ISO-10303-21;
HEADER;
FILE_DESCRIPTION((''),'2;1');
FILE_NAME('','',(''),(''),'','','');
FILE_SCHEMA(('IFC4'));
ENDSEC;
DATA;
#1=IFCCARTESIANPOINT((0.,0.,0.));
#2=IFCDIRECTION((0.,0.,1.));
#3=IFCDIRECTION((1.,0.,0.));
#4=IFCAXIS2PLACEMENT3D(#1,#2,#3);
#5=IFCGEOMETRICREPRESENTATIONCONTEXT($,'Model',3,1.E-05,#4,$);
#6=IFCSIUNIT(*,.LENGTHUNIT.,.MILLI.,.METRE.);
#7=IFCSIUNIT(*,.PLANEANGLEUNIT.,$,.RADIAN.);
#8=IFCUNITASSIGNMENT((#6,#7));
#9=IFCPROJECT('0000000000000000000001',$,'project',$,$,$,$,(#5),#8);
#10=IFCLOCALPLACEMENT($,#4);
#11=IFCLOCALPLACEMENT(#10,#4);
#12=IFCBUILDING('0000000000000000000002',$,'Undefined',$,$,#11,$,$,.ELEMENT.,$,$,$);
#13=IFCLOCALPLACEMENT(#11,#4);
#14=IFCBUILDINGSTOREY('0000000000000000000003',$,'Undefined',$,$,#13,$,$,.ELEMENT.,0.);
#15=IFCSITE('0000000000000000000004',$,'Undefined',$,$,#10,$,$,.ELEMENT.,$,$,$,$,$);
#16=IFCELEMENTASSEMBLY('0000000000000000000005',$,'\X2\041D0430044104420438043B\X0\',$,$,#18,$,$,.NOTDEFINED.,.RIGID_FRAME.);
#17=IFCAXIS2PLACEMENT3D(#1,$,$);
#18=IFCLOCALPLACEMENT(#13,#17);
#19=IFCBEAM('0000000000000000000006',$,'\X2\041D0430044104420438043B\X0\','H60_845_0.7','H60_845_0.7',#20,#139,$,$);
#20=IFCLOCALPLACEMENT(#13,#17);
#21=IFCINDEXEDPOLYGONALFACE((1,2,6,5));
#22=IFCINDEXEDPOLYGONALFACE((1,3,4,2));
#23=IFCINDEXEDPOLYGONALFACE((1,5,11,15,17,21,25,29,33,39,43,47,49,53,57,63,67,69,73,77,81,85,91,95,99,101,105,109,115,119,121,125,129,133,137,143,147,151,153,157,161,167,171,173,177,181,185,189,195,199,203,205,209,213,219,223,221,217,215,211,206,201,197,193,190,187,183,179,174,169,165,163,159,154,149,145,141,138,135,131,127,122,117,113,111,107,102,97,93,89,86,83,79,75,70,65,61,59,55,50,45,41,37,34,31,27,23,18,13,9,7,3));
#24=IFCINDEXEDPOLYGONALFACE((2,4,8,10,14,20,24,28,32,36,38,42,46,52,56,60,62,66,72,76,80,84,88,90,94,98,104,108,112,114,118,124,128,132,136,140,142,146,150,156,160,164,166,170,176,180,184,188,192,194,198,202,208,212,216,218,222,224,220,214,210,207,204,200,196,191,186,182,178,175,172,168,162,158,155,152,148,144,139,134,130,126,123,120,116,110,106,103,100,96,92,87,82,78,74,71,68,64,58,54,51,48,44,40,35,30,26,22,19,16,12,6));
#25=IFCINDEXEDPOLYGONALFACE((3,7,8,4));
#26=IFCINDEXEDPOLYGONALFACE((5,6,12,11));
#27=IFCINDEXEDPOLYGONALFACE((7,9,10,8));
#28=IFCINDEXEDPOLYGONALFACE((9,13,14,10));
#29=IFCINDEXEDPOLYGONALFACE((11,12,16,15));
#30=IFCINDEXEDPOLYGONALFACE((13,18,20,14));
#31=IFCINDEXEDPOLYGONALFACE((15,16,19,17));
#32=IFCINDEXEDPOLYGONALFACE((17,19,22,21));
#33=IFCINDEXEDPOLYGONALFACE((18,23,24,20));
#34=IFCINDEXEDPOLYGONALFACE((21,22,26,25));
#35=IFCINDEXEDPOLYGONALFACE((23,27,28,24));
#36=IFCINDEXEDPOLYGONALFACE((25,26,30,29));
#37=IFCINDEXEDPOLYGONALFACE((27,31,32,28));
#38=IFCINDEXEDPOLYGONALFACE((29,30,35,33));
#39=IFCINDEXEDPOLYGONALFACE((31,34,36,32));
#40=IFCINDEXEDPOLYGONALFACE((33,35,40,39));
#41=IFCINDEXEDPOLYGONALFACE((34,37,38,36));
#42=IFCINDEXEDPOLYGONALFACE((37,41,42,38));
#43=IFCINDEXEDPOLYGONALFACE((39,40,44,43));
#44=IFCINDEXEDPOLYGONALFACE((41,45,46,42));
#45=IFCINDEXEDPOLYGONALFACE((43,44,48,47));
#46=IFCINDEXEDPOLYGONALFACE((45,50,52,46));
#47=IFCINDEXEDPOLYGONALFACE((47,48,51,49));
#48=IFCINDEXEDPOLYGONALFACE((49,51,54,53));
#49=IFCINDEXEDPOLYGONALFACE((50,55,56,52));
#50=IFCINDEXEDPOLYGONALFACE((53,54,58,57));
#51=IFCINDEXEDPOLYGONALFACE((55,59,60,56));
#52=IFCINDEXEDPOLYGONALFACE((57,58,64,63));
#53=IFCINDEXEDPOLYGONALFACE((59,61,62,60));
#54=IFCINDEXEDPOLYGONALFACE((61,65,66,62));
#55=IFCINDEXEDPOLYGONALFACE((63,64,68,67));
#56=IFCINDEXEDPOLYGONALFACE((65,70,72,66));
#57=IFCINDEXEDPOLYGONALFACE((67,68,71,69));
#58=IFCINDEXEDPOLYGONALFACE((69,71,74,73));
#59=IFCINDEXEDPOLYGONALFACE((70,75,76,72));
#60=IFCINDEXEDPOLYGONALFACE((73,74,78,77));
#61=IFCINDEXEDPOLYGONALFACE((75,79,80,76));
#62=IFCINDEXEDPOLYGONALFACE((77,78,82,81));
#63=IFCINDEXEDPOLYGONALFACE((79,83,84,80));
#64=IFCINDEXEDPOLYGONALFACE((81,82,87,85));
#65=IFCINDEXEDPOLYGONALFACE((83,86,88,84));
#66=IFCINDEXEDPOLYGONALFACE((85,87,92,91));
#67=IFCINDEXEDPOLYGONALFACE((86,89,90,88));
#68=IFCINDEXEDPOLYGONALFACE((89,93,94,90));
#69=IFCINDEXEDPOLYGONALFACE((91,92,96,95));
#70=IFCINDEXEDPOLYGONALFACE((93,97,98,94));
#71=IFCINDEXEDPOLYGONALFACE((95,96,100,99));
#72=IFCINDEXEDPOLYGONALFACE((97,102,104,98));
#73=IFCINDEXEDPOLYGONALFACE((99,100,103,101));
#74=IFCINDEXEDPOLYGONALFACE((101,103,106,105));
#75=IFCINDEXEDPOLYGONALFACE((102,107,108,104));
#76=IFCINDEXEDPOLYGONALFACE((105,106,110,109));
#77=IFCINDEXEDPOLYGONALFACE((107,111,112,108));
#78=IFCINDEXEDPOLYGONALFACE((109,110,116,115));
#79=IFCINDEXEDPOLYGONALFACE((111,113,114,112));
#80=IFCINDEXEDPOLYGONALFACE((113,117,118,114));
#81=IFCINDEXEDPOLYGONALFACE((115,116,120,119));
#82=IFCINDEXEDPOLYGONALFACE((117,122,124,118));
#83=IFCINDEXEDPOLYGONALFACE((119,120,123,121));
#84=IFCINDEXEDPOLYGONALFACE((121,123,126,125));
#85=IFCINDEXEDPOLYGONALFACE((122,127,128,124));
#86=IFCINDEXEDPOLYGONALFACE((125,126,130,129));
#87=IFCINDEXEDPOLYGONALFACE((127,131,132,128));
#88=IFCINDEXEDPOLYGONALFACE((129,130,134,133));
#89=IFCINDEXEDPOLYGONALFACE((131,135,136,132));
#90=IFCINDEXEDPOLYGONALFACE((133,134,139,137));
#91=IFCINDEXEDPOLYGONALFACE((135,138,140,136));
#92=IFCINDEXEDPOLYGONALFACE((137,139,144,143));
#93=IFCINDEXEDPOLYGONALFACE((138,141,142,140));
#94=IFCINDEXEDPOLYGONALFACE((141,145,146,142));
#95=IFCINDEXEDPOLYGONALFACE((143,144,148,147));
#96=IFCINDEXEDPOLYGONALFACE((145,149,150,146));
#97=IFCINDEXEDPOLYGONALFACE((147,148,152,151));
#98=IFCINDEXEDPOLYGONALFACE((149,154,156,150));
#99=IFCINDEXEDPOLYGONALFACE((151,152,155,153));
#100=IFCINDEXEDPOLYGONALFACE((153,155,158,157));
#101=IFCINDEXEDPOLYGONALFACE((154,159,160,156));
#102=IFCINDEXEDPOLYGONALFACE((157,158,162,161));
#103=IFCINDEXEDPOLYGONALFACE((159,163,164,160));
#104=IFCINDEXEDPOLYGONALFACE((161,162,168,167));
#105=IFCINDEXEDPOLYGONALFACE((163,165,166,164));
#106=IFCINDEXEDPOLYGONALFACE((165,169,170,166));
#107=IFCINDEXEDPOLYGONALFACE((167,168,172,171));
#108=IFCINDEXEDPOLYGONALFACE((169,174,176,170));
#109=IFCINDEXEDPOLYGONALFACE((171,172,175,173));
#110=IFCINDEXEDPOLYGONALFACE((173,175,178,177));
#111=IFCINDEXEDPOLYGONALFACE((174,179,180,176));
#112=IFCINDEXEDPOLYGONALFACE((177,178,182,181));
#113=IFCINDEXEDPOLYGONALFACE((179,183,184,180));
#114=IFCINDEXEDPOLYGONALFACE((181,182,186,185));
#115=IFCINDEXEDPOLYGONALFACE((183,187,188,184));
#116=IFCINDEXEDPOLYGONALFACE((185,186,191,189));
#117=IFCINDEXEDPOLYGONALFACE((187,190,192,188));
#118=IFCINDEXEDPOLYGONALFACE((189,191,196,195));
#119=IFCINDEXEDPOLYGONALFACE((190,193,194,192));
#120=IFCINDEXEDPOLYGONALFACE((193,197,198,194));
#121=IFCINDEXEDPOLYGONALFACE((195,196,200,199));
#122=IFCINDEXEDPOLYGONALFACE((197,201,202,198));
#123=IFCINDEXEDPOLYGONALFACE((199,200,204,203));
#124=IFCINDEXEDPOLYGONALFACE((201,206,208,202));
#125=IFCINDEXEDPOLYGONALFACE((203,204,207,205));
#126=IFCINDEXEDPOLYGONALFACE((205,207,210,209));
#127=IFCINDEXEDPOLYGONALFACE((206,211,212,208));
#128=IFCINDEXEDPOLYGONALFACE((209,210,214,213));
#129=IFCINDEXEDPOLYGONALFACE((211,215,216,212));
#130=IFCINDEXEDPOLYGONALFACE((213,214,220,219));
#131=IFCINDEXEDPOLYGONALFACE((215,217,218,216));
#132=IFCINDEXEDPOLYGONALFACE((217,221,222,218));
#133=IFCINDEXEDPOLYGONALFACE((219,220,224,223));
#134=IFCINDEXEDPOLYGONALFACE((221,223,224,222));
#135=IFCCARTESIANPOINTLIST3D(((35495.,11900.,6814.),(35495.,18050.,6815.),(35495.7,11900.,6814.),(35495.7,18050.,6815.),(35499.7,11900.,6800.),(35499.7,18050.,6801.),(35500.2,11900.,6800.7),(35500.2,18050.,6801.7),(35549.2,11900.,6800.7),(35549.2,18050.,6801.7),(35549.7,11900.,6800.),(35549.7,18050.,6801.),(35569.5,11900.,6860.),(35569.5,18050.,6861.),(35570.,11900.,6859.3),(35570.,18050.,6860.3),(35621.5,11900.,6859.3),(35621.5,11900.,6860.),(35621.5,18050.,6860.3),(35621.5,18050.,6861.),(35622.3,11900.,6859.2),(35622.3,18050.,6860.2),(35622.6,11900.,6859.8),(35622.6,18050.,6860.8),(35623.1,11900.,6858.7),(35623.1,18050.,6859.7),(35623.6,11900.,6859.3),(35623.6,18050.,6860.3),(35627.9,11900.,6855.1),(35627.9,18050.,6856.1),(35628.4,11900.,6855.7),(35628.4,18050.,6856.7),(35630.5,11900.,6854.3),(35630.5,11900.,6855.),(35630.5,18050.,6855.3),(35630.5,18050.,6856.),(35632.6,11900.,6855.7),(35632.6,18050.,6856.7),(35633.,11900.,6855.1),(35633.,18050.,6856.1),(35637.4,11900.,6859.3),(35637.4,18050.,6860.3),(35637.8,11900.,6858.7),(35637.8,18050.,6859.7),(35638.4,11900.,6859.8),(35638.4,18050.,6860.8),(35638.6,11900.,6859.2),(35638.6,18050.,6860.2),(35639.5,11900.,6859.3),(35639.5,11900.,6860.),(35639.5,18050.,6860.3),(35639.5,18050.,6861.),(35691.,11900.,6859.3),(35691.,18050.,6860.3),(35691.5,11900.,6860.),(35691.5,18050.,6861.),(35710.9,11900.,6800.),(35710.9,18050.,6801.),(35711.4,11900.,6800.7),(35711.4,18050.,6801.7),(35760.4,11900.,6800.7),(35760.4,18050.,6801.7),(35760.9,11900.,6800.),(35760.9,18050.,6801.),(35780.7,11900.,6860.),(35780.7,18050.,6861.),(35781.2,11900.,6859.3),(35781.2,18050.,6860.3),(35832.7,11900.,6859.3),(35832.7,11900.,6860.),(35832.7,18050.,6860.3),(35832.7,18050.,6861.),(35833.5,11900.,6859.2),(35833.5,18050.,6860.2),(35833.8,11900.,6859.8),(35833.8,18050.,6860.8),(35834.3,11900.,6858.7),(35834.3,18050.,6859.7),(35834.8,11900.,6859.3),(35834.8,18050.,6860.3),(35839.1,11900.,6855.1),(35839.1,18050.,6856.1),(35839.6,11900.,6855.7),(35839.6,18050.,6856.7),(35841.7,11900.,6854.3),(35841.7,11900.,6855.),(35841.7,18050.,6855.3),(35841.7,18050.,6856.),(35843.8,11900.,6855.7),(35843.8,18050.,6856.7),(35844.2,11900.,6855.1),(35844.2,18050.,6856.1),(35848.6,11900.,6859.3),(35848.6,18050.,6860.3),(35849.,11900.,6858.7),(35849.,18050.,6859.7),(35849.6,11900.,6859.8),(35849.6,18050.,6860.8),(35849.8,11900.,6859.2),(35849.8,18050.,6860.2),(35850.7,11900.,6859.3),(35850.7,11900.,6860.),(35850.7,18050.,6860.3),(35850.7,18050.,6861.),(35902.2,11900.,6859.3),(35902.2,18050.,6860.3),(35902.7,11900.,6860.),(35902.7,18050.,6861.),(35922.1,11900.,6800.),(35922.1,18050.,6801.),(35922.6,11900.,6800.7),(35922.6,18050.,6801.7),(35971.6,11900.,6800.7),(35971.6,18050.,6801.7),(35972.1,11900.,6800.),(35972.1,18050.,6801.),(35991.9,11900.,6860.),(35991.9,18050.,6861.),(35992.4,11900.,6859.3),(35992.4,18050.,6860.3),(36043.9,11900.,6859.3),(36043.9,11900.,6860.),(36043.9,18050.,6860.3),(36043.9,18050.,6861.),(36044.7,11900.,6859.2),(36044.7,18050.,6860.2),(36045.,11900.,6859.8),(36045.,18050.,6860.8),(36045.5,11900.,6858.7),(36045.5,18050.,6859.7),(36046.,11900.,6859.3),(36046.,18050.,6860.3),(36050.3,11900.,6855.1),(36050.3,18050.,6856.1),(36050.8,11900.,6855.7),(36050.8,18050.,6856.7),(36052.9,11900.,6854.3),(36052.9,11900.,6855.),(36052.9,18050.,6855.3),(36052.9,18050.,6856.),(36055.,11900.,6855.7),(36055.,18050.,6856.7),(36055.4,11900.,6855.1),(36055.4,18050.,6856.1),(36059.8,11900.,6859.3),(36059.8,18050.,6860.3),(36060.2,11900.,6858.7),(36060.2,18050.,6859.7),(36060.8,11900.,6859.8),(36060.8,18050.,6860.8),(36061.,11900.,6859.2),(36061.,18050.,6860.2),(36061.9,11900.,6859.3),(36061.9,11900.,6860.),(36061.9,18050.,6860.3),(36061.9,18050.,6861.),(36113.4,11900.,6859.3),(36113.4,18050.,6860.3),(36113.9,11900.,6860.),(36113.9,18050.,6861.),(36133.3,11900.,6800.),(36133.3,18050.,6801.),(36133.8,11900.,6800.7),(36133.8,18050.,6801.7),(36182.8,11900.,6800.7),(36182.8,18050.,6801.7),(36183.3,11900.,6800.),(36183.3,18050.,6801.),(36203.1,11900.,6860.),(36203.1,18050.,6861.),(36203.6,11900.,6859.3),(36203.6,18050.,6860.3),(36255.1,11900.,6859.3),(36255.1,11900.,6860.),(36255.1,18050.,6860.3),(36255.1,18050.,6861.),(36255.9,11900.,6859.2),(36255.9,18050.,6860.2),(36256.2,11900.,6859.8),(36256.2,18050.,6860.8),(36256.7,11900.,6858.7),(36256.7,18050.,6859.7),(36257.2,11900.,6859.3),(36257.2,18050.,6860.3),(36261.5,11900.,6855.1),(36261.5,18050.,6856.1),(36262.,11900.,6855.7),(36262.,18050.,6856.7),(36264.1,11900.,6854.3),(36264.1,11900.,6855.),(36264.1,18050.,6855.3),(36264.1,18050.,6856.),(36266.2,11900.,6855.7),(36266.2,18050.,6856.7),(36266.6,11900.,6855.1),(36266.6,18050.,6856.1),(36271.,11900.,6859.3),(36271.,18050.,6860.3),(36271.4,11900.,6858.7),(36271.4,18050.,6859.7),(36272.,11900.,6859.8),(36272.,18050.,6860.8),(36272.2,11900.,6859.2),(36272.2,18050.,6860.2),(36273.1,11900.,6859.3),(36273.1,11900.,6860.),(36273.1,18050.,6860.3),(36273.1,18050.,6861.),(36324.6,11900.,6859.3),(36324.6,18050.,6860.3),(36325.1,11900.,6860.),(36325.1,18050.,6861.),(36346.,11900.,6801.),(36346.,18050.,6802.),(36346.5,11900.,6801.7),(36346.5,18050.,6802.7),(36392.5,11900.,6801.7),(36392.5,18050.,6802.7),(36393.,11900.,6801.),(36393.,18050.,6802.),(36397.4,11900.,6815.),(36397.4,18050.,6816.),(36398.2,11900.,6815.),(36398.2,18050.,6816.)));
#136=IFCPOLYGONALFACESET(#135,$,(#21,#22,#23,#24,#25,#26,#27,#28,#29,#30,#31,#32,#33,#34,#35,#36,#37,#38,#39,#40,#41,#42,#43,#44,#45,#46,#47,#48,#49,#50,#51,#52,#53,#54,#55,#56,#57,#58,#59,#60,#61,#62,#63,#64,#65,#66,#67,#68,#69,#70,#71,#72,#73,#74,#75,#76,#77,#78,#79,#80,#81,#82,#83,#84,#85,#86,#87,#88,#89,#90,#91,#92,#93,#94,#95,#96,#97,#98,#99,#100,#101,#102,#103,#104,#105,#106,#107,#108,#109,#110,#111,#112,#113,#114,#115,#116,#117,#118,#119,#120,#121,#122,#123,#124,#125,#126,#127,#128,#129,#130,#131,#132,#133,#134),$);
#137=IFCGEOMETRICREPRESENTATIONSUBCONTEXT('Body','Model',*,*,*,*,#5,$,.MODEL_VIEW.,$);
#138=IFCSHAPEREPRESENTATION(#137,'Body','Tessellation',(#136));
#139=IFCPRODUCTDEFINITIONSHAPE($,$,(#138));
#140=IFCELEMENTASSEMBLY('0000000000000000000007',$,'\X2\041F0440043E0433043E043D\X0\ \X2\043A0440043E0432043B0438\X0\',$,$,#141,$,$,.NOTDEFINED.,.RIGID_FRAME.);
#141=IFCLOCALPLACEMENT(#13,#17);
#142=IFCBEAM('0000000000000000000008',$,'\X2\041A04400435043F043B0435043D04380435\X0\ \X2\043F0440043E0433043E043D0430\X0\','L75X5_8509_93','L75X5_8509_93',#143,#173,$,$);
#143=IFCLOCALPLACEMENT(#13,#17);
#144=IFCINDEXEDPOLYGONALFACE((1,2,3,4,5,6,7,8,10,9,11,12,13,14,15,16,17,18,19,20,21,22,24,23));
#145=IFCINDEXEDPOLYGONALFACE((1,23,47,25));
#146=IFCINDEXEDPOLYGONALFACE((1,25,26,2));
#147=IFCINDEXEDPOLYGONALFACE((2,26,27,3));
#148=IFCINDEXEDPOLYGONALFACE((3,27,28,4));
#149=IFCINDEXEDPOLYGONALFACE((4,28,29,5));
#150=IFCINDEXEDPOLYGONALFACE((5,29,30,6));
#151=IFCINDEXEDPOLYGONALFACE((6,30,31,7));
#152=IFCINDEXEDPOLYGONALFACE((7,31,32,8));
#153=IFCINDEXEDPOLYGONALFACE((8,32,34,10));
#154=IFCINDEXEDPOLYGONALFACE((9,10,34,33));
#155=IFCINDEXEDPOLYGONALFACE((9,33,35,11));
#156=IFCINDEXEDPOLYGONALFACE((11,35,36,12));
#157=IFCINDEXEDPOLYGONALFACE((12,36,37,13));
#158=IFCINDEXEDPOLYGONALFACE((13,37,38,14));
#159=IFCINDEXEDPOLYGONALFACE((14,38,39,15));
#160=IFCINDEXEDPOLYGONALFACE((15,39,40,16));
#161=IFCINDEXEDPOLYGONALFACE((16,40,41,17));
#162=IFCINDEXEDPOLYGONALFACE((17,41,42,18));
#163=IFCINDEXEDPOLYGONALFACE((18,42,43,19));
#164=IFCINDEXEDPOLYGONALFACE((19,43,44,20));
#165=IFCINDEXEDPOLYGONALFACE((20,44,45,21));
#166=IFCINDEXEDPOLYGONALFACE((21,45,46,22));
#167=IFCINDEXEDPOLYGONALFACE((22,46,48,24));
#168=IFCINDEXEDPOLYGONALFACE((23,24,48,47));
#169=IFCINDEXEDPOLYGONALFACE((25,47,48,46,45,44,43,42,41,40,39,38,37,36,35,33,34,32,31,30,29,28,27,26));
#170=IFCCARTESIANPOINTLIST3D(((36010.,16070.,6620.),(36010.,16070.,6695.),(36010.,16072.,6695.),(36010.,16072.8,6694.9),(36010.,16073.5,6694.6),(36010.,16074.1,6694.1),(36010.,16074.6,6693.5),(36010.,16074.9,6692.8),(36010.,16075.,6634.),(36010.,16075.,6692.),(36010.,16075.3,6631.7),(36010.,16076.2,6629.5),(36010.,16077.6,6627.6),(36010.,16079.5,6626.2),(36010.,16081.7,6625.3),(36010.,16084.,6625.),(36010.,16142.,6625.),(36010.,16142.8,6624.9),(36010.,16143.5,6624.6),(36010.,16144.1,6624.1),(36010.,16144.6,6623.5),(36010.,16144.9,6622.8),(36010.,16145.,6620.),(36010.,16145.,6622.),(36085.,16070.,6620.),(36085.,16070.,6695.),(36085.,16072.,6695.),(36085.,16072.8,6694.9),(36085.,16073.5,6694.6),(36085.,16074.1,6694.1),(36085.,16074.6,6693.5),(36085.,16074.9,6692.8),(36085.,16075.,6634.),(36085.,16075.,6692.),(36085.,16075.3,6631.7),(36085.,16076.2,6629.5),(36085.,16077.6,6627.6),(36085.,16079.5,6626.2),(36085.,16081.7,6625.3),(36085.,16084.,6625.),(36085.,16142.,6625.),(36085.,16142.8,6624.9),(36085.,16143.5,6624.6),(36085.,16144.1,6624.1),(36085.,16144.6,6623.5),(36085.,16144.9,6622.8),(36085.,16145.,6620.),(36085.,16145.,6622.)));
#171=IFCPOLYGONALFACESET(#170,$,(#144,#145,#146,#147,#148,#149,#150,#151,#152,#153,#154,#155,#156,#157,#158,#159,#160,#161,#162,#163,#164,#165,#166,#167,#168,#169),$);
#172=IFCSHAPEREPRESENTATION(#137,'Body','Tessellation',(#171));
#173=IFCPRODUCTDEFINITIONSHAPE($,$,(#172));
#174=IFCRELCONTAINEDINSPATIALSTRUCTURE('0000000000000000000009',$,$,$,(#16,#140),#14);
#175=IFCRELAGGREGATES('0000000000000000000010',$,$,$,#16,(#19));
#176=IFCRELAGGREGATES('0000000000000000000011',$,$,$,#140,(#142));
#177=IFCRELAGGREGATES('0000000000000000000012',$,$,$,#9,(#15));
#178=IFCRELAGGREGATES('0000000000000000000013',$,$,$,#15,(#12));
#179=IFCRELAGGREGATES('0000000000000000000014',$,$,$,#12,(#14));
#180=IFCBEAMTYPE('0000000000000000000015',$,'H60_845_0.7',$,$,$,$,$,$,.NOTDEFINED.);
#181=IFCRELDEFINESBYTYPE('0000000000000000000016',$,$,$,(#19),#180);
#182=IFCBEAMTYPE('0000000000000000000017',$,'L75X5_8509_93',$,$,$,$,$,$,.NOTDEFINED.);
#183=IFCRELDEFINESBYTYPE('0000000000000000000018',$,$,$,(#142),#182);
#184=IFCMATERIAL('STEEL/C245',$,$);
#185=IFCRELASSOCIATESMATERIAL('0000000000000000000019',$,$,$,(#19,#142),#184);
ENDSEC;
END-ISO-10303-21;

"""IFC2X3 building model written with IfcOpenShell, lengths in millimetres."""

from ifc_helpers import new_model, si_unit, frame, origin_with_axes, origin_2d_with_axis, place, context, subcontext, project, spatial, polyline, l_section, outline, extrude, material, type_object, element, aggregate, save


model = new_model("IFC2X3")

# Units and contexts
model_context = context("Model", 3, precision=1e-05, world=origin_with_axes())
body_context = subcontext(model_context, "Body", "Model", "MODEL_VIEW")
ifc_project = project(units=[si_unit("LENGTHUNIT", "METRE", prefix="MILLI"), si_unit("PLANEANGLEUNIT", "RADIAN")], contexts=[model_context])

# Site, building, storey
site_placement = place(None, origin_with_axes())
site = spatial("IfcSite", under=ifc_project, at=site_placement, Name="Undefined", CompositionType="ELEMENT")
building_placement = place(site_placement, origin_with_axes())
building = spatial("IfcBuilding", under=site, at=building_placement, Name="Undefined", CompositionType="ELEMENT")
storey_placement = place(building_placement, origin_with_axes())
storey = spatial("IfcBuildingStorey", under=building, at=storey_placement, Name="Undefined", CompositionType="ELEMENT", Elevation=0.0)

# Element assembly, beam
ifc_material_1 = material(Name="STEEL/C245")
beam_type_1 = type_object("IfcBeamType", Name="H60_845_0.7", PredefinedType="NOTDEFINED")
assembly_1_placement = place(storey_placement, origin_with_axes())
assembly_1 = element("IfcElementAssembly", 1, at=assembly_1_placement, inside=storey, Name="Настил", AssemblyPlace="NOTDEFINED", PredefinedType="RIGID_FRAME")
beam_1_placement = place(assembly_1_placement, frame((35946.2, 18050.0, 6831.0), z_axis=(0.0, -0.000163, 1.0), x_axis=(0.0, -1.0, -0.000163)))
beam_1 = element("IfcBeam", 2, at=beam_1_placement, type_object=beam_type_1, material=ifc_material_1, Name="Настил", Description="H60_845_0.7", ObjectType="H60_845_0.7", context=body_context, shape_type="SweptSolid", body=[
    extrude(outline(polyline([(-399.8, -29.0), (-446.8, -29.0), (-452.0, -15.0), (-451.2, -15.0), (-446.3, -28.3), (-400.3, -28.3), (-378.9, 30.0), (-326.9, 30.0), (-325.7, 29.8), (-324.7, 29.3), (-320.0, 25.7), (-317.9, 25.0), (-315.8, 25.7), (-311.0, 29.3), (-310.0, 29.8), (-308.9, 30.0), (-256.9, 30.0), (-236.6, -29.3), (-187.6, -29.3), (-167.7, 30.0), (-115.7, 30.0), (-114.5, 29.8), (-113.5, 29.3), (-108.8, 25.7), (-106.7, 25.0), (-104.6, 25.7), (-99.7, 29.3), (-98.8, 29.8), (-97.7, 30.0), (-45.7, 30.0), (-25.4, -29.3), (23.6, -29.3), (43.5, 30.0), (95.5, 30.0), (96.7, 29.8), (97.7, 29.3), (102.4, 25.7), (104.5, 25.0), (106.6, 25.7), (111.4, 29.3), (112.4, 29.8), (113.5, 30.0), (165.5, 30.0), (185.8, -29.3), (234.8, -29.3), (254.7, 30.0), (306.7, 30.0), (307.9, 29.8), (308.9, 29.3), (313.6, 25.7), (315.7, 25.0), (317.8, 25.7), (322.6, 29.3), (323.6, 29.8), (324.7, 30.0), (376.7, 30.0), (397.0, -29.3), (446.0, -29.3), (450.5, -16.0), (451.2, -16.0), (446.5, -30.0), (396.5, -30.0), (376.2, 29.3), (324.7, 29.3), (323.9, 29.2), (323.1, 28.7), (318.3, 25.1), (315.7, 24.3), (313.2, 25.1), (308.4, 28.7), (307.6, 29.2), (306.7, 29.3), (255.2, 29.3), (235.3, -30.0), (185.3, -30.0), (165.0, 29.3), (113.5, 29.3), (112.7, 29.2), (111.9, 28.7), (107.1, 25.1), (104.5, 24.3), (102.0, 25.1), (97.2, 28.7), (96.4, 29.2), (95.5, 29.3), (44.0, 29.3), (24.1, -30.0), (-25.9, -30.0), (-46.2, 29.3), (-97.7, 29.3), (-98.5, 29.2), (-99.3, 28.7), (-104.1, 25.1), (-106.7, 24.3), (-109.2, 25.1), (-114.0, 28.7), (-114.8, 29.2), (-115.7, 29.3), (-167.2, 29.3), (-187.1, -30.0), (-237.1, -30.0), (-257.4, 29.3), (-308.9, 29.3), (-309.7, 29.2), (-310.5, 28.7), (-315.3, 25.1), (-317.9, 24.3), (-320.4, 25.1), (-325.2, 28.7), (-326.0, 29.2), (-326.9, 29.3), (-378.4, 29.3), (-399.8, -29.0)])), frame((6150.0, 0.0, 0.0), z_axis=(-1.0, 0.0, 0.0), x_axis=(0.0, -1.0, 0.0)), (0.0, 0.0, 1.0), 6150.0),
])
aggregate(assembly_1, [beam_1])

# Element assembly, beam
assembly_2_placement = place(storey_placement, origin_with_axes())
assembly_2 = element("IfcElementAssembly", 3, at=assembly_2_placement, inside=storey, Name="Прогон кровли", AssemblyPlace="NOTDEFINED", PredefinedType="RIGID_FRAME")
beam_type_2 = type_object("IfcBeamType", Name="L75X5_8509_93", PredefinedType="NOTDEFINED")
beam_2_placement = place(assembly_2_placement, frame((36010.0, 16107.5, 6657.5), z_axis=(0.0, 1.0, 0.0), x_axis=(1.0, 0.0, 0.0)))
beam_2 = element("IfcBeam", 4, at=beam_2_placement, type_object=beam_type_2, material=ifc_material_1, Name="Крепление прогона", Description="L75X5_8509_93", ObjectType="L75X5_8509_93", context=body_context, shape_type="SweptSolid", body=[
    extrude(l_section(Depth=75.0, Width=75.0, Thickness=5.0, FilletRadius=9.0, EdgeRadius=3.0, at=origin_2d_with_axis()), frame((75.0, 0.0, 0.0), z_axis=(-1.0, 0.0, 0.0), x_axis=(0.0, -1.0, 0.0)), (0.0, 0.0, 1.0), 75.0),
])

aggregate(assembly_2, [beam_2])

save(model, "model.ifc")
